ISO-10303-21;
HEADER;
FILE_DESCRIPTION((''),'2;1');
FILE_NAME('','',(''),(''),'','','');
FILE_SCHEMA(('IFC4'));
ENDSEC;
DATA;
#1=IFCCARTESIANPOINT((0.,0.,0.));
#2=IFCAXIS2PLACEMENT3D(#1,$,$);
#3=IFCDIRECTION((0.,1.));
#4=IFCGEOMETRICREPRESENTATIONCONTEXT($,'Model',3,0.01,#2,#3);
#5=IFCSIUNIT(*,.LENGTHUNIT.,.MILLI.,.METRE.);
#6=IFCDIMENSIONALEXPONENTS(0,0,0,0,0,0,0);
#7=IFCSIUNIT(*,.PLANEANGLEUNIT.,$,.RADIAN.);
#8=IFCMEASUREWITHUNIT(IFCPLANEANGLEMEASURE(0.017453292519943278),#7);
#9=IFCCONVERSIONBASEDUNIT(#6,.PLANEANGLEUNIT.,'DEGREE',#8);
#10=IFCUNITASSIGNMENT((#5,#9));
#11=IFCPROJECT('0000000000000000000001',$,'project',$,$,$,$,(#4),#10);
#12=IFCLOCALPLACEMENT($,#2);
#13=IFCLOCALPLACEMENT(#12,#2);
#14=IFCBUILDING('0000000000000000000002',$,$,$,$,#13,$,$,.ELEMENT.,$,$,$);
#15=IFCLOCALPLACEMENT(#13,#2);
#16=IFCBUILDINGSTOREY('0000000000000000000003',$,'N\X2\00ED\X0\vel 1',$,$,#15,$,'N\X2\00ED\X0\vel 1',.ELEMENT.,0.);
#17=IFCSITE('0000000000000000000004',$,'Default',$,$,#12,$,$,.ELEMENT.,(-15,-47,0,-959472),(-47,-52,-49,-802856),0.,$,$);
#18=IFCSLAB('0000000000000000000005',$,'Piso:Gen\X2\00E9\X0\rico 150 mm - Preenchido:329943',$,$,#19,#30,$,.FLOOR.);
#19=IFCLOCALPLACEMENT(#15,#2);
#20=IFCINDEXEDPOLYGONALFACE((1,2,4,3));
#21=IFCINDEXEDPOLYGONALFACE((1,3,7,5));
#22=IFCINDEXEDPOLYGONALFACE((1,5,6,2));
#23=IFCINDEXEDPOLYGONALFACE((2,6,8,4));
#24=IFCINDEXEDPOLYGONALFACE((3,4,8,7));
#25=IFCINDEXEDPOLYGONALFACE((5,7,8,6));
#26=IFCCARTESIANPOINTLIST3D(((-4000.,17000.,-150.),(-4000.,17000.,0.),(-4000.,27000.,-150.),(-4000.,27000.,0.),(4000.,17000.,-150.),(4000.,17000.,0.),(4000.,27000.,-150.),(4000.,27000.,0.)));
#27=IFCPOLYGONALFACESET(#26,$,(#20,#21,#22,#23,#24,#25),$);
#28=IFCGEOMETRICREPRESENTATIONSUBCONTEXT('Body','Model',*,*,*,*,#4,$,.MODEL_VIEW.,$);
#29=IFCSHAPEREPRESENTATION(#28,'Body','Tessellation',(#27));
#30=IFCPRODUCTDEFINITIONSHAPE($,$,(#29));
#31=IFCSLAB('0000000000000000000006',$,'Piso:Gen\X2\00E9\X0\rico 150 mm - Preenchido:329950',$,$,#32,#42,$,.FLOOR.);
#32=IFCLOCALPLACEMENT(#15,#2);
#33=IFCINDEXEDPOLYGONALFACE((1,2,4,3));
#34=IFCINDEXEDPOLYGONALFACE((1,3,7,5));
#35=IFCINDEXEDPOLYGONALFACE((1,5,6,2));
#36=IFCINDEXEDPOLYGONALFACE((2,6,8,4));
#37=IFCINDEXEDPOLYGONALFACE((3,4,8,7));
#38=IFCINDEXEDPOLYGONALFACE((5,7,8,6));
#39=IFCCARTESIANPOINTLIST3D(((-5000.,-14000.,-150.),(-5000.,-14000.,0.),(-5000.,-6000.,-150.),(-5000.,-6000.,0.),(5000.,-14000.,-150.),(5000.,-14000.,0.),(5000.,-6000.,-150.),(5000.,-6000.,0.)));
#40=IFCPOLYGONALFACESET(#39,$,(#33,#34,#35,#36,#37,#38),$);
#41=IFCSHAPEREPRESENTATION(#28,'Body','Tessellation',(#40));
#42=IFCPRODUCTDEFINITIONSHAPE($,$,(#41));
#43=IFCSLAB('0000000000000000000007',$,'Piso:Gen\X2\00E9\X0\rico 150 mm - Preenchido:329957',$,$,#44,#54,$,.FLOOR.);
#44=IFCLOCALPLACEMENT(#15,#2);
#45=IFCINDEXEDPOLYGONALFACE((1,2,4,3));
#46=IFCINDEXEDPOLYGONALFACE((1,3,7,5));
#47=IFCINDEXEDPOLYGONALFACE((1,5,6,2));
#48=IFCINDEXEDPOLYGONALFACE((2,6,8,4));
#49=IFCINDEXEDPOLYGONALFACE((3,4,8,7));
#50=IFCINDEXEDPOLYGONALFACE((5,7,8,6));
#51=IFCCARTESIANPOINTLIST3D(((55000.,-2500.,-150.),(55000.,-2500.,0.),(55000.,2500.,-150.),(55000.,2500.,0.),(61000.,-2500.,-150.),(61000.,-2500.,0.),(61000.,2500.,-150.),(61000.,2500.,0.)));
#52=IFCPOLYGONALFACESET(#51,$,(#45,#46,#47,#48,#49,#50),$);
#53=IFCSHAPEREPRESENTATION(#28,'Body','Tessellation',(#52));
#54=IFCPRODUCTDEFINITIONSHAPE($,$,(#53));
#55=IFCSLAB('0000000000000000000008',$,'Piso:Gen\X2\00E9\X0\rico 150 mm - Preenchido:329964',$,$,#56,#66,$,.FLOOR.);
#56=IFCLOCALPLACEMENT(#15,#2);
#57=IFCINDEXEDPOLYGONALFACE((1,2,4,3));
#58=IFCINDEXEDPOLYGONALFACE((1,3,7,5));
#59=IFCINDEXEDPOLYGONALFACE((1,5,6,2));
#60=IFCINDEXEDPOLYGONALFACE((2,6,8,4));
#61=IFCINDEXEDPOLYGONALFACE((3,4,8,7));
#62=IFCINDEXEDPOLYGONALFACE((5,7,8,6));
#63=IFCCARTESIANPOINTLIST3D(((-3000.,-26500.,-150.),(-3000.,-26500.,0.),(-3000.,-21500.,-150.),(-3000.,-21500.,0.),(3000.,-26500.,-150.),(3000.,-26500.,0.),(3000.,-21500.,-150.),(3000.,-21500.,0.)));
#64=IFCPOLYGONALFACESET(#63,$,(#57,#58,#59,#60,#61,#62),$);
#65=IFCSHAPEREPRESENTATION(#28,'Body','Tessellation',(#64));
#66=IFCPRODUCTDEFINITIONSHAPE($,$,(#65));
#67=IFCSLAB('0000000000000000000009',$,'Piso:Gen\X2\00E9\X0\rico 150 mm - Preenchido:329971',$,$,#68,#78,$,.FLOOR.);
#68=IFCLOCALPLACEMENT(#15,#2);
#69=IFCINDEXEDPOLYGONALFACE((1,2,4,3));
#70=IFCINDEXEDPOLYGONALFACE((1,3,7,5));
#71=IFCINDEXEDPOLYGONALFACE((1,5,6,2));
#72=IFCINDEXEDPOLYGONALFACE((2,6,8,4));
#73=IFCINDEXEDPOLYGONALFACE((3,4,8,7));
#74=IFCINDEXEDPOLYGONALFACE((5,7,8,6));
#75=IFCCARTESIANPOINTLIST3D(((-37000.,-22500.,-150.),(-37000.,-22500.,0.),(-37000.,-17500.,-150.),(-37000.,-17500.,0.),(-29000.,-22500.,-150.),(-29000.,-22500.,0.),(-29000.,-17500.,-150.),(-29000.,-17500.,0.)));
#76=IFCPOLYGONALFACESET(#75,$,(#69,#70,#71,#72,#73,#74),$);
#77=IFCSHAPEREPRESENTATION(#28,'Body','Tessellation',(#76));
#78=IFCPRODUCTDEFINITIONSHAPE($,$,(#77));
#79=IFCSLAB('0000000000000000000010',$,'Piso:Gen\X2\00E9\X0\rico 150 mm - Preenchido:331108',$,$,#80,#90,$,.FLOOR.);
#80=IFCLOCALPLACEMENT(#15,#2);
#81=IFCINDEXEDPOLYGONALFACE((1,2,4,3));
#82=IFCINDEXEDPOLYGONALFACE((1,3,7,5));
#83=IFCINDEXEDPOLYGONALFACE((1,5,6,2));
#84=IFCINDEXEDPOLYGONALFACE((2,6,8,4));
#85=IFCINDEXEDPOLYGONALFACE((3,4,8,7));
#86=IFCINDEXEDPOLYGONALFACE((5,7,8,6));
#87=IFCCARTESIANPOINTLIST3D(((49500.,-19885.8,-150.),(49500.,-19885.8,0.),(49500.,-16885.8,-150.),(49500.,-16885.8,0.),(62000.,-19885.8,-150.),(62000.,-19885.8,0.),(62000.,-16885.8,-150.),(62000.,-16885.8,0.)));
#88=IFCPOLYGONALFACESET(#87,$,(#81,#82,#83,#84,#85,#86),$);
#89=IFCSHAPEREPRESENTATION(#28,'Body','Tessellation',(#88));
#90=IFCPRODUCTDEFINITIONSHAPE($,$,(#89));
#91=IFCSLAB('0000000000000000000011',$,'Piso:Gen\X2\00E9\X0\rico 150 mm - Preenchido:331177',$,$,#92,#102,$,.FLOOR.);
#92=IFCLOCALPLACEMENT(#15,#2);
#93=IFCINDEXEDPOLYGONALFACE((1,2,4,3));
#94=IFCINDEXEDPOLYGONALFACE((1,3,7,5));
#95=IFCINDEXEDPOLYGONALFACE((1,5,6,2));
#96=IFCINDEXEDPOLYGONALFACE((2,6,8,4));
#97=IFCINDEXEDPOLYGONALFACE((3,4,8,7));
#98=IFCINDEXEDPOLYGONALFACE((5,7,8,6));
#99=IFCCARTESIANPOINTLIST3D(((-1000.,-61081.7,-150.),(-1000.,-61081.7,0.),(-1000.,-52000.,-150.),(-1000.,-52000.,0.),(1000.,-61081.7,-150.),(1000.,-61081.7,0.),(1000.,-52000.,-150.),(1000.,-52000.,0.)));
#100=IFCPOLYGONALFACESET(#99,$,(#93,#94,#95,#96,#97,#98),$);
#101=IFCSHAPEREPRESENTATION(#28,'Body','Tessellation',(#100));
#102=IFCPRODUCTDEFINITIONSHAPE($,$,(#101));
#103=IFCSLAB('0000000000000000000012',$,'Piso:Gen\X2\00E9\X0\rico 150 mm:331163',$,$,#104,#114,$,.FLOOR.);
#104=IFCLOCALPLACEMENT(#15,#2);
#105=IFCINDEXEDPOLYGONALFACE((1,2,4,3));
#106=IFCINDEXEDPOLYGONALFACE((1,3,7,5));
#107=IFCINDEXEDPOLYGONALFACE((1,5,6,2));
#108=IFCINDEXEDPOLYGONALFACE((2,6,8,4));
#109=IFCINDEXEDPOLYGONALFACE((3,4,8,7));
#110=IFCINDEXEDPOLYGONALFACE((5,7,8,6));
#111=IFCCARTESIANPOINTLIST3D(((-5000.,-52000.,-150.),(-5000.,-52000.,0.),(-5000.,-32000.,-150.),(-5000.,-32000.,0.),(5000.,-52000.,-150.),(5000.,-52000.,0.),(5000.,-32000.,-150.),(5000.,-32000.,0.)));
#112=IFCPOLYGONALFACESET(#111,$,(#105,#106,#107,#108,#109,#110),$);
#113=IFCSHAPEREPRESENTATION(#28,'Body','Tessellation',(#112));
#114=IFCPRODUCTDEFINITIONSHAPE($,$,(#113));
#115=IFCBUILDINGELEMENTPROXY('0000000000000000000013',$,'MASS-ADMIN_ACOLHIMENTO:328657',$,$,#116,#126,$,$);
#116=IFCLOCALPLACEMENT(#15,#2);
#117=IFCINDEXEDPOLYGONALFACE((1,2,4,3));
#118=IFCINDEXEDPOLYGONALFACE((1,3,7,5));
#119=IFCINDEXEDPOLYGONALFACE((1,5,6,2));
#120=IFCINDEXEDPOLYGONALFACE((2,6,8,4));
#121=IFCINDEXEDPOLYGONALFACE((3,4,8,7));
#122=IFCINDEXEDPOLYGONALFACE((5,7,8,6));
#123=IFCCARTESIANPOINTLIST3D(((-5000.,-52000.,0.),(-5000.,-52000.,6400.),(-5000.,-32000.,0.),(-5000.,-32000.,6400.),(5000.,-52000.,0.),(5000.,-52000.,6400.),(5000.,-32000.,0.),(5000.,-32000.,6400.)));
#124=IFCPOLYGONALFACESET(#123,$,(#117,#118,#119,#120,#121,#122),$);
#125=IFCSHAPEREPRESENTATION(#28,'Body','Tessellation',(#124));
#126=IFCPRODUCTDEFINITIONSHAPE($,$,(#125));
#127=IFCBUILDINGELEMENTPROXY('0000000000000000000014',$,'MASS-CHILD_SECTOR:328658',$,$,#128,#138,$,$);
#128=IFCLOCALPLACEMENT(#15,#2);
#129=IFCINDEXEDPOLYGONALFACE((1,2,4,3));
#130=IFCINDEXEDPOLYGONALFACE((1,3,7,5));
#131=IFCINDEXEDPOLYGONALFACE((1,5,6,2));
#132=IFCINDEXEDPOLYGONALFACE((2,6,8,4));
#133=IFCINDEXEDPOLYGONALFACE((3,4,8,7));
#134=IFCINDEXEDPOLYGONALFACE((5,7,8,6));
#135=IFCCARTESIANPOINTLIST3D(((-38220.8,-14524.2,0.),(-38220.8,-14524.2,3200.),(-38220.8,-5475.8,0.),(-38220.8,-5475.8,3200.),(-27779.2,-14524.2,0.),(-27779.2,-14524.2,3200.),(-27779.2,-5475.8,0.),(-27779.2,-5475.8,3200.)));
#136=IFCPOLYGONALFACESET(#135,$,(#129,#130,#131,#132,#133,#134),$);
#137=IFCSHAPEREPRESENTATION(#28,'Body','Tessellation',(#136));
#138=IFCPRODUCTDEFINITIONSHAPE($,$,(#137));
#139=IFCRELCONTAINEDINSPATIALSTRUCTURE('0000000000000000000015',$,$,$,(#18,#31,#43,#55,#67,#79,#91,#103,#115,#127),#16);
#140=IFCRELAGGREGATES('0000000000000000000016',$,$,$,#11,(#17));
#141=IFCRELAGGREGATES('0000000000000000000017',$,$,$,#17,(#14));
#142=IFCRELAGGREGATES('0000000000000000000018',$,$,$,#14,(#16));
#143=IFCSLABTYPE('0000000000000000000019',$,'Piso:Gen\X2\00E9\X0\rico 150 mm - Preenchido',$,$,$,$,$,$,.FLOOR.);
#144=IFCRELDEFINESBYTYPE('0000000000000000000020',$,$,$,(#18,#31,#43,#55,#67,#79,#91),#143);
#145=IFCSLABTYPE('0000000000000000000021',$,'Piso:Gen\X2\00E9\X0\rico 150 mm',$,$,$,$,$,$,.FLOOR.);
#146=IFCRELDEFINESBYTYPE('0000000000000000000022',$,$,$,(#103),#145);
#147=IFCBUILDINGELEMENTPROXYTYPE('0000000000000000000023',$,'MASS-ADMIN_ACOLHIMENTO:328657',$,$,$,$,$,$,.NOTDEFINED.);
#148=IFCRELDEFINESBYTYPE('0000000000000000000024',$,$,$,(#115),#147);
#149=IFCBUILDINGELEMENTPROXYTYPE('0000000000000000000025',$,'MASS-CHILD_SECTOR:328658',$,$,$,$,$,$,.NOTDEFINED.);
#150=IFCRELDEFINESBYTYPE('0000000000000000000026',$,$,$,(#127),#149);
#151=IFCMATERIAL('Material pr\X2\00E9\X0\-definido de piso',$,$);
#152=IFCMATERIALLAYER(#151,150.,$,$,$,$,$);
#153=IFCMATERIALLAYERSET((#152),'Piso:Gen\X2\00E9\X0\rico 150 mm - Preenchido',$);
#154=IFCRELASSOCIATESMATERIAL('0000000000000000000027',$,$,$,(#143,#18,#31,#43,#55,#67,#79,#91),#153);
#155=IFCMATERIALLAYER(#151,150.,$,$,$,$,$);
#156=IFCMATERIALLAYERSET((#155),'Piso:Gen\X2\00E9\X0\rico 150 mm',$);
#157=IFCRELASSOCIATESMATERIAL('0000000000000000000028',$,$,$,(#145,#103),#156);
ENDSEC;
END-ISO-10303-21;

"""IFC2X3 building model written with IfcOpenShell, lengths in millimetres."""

from ifc_helpers import new_model, entity, si_unit, converted_unit, direction, frame, frame_2d, origin, origin_2d_with_axis, place, context, subcontext, project, spatial, rectangle, extrude, material, layer, layer_set, layer_usage, type_object, element, save


model = new_model("IFC2X3")

# Units and contexts
model_context = context("Model", 3, precision=0.01, world=origin(), true_north=direction((0.0, 1.0)))
body_context = subcontext(model_context, "Body", "Model", "MODEL_VIEW")
ifc_project = project(units=[si_unit("LENGTHUNIT", "METRE", prefix="MILLI"), converted_unit("PLANEANGLEUNIT", "DEGREE", entity("IfcPlaneAngleMeasure", 0.017453292519943278), si_unit("PLANEANGLEUNIT", "RADIAN"), dimensions=[0, 0, 0, 0, 0, 0, 0])], contexts=[model_context])

# Site, building, storey
site_placement = place(None, origin())
site = spatial("IfcSite", under=ifc_project, at=site_placement, Name="Default", CompositionType="ELEMENT", RefLatitude=(-15, -47, 0, -959472), RefLongitude=(-47, -52, -49, -802856), RefElevation=0.0)
building_placement = place(site_placement, origin())
building = spatial("IfcBuilding", under=site, at=building_placement, CompositionType="ELEMENT")
storey_placement = place(building_placement, origin())
storey = spatial("IfcBuildingStorey", under=building, at=storey_placement, Name="Nível 1", LongName="Nível 1", CompositionType="ELEMENT", Elevation=0.0)

# Slabs
ifc_material_1 = material(Name="Material pré-definido de piso")
ifc_layer_1 = layer(ifc_material_1, 150.0)
ifc_layer_set_1 = layer_set([ifc_layer_1], Name="Piso:Genérico 150 mm - Preenchido")
ifc_layer_usage_1 = layer_usage(ifc_layer_set_1, "AXIS3", "POSITIVE", 0.0)
slab_type_1 = type_object("IfcSlabType", Name="Piso:Genérico 150 mm - Preenchido", PredefinedType="FLOOR", material=ifc_layer_set_1)
slab_1_placement = place(storey_placement, origin())
element("IfcSlab", 1, at=slab_1_placement, inside=storey, type_object=slab_type_1, material=ifc_layer_usage_1, Name="Piso:Genérico 150 mm - Preenchido:329943", PredefinedType="FLOOR", context=body_context, shape_type="SweptSolid", body=[
    extrude(rectangle(XDim=10000.0, YDim=8000.0, at=frame_2d((0.0, 0.0), x_axis=(1.0, 0.0))), frame((0.0, 22000.0, 0.0), z_axis=(0.0, 0.0, -1.0), x_axis=(0.0, 1.0, 0.0)), (0.0, 0.0, 1.0), 150.0),
])
ifc_layer_usage_2 = layer_usage(ifc_layer_set_1, "AXIS3", "POSITIVE", 0.0)
slab_2_placement = place(storey_placement, origin())
element("IfcSlab", 2, at=slab_2_placement, inside=storey, type_object=slab_type_1, material=ifc_layer_usage_2, Name="Piso:Genérico 150 mm - Preenchido:329950", PredefinedType="FLOOR", context=body_context, shape_type="SweptSolid", body=[
    extrude(rectangle(XDim=8000.0, YDim=10000.0, at=frame_2d((0.0, 0.0), x_axis=(1.0, 0.0))), frame((0.0, -10000.0, 0.0), z_axis=(0.0, 0.0, -1.0), x_axis=(0.0, 1.0, 0.0)), (0.0, 0.0, 1.0), 150.0),
])
ifc_layer_usage_3 = layer_usage(ifc_layer_set_1, "AXIS3", "POSITIVE", 0.0)
slab_3_placement = place(storey_placement, origin())
element("IfcSlab", 3, at=slab_3_placement, inside=storey, type_object=slab_type_1, material=ifc_layer_usage_3, Name="Piso:Genérico 150 mm - Preenchido:329957", PredefinedType="FLOOR", context=body_context, shape_type="SweptSolid", body=[
    extrude(rectangle(XDim=5000.0, YDim=6000.0, at=frame_2d((0.0, 0.0), x_axis=(1.0, 0.0))), frame((58000.0, 0.0, 0.0), z_axis=(0.0, 0.0, -1.0), x_axis=(0.0, 1.0, 0.0)), (0.0, 0.0, 1.0), 150.0),
])
ifc_layer_usage_4 = layer_usage(ifc_layer_set_1, "AXIS3", "POSITIVE", 0.0)
slab_4_placement = place(storey_placement, origin())
element("IfcSlab", 4, at=slab_4_placement, inside=storey, type_object=slab_type_1, material=ifc_layer_usage_4, Name="Piso:Genérico 150 mm - Preenchido:329964", PredefinedType="FLOOR", context=body_context, shape_type="SweptSolid", body=[
    extrude(rectangle(XDim=5000.0, YDim=6000.0, at=origin_2d_with_axis()), frame((0.0, -24000.0, 0.0), z_axis=(0.0, 0.0, -1.0), x_axis=(0.0, 1.0, 0.0)), (0.0, 0.0, 1.0), 150.0),
])
ifc_layer_usage_5 = layer_usage(ifc_layer_set_1, "AXIS3", "POSITIVE", 0.0)
slab_5_placement = place(storey_placement, origin())
element("IfcSlab", 5, at=slab_5_placement, inside=storey, type_object=slab_type_1, material=ifc_layer_usage_5, Name="Piso:Genérico 150 mm - Preenchido:329971", PredefinedType="FLOOR", context=body_context, shape_type="SweptSolid", body=[
    extrude(rectangle(XDim=5000.0, YDim=8000.0, at=frame_2d((0.0, 0.0), x_axis=(1.0, 0.0))), frame((-33000.0, -20000.0, 0.0), z_axis=(0.0, 0.0, -1.0), x_axis=(0.0, 1.0, 0.0)), (0.0, 0.0, 1.0), 150.0),
])
ifc_layer_usage_6 = layer_usage(ifc_layer_set_1, "AXIS3", "POSITIVE", 0.0)
slab_6_placement = place(storey_placement, origin())
element("IfcSlab", 6, at=slab_6_placement, inside=storey, type_object=slab_type_1, material=ifc_layer_usage_6, Name="Piso:Genérico 150 mm - Preenchido:331108", PredefinedType="FLOOR", context=body_context, shape_type="SweptSolid", body=[
    extrude(rectangle(XDim=3000.0, YDim=12500.0, at=frame_2d((0.0, 0.0), x_axis=(1.0, 0.0))), frame((55750.0, -18385.8, 0.0), z_axis=(0.0, 0.0, -1.0), x_axis=(0.0, 1.0, 0.0)), (0.0, 0.0, 1.0), 150.0),
])
ifc_layer_usage_7 = layer_usage(ifc_layer_set_1, "AXIS3", "POSITIVE", 0.0)
slab_7_placement = place(storey_placement, origin())
element("IfcSlab", 7, at=slab_7_placement, inside=storey, type_object=slab_type_1, material=ifc_layer_usage_7, Name="Piso:Genérico 150 mm - Preenchido:331177", PredefinedType="FLOOR", context=body_context, shape_type="SweptSolid", body=[
    extrude(rectangle(XDim=9081.7, YDim=2000.0, at=origin_2d_with_axis()), frame((0.0, -56540.8, 0.0), z_axis=(0.0, 0.0, -1.0), x_axis=(0.0, 1.0, 0.0)), (0.0, 0.0, 1.0), 150.0),
])
ifc_layer_2 = layer(ifc_material_1, 150.0)
ifc_layer_set_2 = layer_set([ifc_layer_2], Name="Piso:Genérico 150 mm")
slab_type_2 = type_object("IfcSlabType", Name="Piso:Genérico 150 mm", PredefinedType="FLOOR", material=ifc_layer_set_2)
ifc_layer_usage_8 = layer_usage(ifc_layer_set_2, "AXIS3", "POSITIVE", 0.0)
slab_8_placement = place(storey_placement, origin())
element("IfcSlab", 8, at=slab_8_placement, inside=storey, type_object=slab_type_2, material=ifc_layer_usage_8, Name="Piso:Genérico 150 mm:331163", PredefinedType="FLOOR", context=body_context, shape_type="SweptSolid", body=[
    extrude(rectangle(XDim=20000.0, YDim=10000.0, at=frame_2d((0.0, 0.0), x_axis=(1.0, 0.0))), frame((0.0, -42000.0, 0.0), z_axis=(0.0, 0.0, -1.0), x_axis=(0.0, 1.0, 0.0)), (0.0, 0.0, 1.0), 150.0),
])

# Building element proxies
building_element_proxy_type_1 = type_object("IfcBuildingElementProxyType", Name="MASS-ADMIN_ACOLHIMENTO:328657", PredefinedType="NOTDEFINED")
proxy_1_placement = place(storey_placement, origin())
element("IfcBuildingElementProxy", 9, at=proxy_1_placement, inside=storey, type_object=building_element_proxy_type_1, Name="MASS-ADMIN_ACOLHIMENTO:328657", context=body_context, shape_type="SweptSolid", body=[
    extrude(rectangle(XDim=10000.0, YDim=20000.0, at=frame_2d((0.0, 0.0), x_axis=(1.0, 0.0))), frame((0.0, -42000.0, 0.0)), (0.0, 0.0, 1.0), 6400.0),
])
building_element_proxy_type_2 = type_object("IfcBuildingElementProxyType", Name="MASS-CHILD_SECTOR:328658", PredefinedType="NOTDEFINED")
proxy_2_placement = place(storey_placement, origin())
element("IfcBuildingElementProxy", 10, at=proxy_2_placement, inside=storey, type_object=building_element_proxy_type_2, Name="MASS-CHILD_SECTOR:328658", context=body_context, shape_type="SweptSolid", body=[
    extrude(rectangle(XDim=9048.5, YDim=10441.6, at=frame_2d((0.0, 0.0), x_axis=(1.0, 0.0))), frame((-33000.0, -10000.0, 0.0), z_axis=(0.0, 0.0, 1.0), x_axis=(0.0, 1.0, 0.0)), (0.0, 0.0, 1.0), 3200.0),
])

save(model, "model.ifc")
